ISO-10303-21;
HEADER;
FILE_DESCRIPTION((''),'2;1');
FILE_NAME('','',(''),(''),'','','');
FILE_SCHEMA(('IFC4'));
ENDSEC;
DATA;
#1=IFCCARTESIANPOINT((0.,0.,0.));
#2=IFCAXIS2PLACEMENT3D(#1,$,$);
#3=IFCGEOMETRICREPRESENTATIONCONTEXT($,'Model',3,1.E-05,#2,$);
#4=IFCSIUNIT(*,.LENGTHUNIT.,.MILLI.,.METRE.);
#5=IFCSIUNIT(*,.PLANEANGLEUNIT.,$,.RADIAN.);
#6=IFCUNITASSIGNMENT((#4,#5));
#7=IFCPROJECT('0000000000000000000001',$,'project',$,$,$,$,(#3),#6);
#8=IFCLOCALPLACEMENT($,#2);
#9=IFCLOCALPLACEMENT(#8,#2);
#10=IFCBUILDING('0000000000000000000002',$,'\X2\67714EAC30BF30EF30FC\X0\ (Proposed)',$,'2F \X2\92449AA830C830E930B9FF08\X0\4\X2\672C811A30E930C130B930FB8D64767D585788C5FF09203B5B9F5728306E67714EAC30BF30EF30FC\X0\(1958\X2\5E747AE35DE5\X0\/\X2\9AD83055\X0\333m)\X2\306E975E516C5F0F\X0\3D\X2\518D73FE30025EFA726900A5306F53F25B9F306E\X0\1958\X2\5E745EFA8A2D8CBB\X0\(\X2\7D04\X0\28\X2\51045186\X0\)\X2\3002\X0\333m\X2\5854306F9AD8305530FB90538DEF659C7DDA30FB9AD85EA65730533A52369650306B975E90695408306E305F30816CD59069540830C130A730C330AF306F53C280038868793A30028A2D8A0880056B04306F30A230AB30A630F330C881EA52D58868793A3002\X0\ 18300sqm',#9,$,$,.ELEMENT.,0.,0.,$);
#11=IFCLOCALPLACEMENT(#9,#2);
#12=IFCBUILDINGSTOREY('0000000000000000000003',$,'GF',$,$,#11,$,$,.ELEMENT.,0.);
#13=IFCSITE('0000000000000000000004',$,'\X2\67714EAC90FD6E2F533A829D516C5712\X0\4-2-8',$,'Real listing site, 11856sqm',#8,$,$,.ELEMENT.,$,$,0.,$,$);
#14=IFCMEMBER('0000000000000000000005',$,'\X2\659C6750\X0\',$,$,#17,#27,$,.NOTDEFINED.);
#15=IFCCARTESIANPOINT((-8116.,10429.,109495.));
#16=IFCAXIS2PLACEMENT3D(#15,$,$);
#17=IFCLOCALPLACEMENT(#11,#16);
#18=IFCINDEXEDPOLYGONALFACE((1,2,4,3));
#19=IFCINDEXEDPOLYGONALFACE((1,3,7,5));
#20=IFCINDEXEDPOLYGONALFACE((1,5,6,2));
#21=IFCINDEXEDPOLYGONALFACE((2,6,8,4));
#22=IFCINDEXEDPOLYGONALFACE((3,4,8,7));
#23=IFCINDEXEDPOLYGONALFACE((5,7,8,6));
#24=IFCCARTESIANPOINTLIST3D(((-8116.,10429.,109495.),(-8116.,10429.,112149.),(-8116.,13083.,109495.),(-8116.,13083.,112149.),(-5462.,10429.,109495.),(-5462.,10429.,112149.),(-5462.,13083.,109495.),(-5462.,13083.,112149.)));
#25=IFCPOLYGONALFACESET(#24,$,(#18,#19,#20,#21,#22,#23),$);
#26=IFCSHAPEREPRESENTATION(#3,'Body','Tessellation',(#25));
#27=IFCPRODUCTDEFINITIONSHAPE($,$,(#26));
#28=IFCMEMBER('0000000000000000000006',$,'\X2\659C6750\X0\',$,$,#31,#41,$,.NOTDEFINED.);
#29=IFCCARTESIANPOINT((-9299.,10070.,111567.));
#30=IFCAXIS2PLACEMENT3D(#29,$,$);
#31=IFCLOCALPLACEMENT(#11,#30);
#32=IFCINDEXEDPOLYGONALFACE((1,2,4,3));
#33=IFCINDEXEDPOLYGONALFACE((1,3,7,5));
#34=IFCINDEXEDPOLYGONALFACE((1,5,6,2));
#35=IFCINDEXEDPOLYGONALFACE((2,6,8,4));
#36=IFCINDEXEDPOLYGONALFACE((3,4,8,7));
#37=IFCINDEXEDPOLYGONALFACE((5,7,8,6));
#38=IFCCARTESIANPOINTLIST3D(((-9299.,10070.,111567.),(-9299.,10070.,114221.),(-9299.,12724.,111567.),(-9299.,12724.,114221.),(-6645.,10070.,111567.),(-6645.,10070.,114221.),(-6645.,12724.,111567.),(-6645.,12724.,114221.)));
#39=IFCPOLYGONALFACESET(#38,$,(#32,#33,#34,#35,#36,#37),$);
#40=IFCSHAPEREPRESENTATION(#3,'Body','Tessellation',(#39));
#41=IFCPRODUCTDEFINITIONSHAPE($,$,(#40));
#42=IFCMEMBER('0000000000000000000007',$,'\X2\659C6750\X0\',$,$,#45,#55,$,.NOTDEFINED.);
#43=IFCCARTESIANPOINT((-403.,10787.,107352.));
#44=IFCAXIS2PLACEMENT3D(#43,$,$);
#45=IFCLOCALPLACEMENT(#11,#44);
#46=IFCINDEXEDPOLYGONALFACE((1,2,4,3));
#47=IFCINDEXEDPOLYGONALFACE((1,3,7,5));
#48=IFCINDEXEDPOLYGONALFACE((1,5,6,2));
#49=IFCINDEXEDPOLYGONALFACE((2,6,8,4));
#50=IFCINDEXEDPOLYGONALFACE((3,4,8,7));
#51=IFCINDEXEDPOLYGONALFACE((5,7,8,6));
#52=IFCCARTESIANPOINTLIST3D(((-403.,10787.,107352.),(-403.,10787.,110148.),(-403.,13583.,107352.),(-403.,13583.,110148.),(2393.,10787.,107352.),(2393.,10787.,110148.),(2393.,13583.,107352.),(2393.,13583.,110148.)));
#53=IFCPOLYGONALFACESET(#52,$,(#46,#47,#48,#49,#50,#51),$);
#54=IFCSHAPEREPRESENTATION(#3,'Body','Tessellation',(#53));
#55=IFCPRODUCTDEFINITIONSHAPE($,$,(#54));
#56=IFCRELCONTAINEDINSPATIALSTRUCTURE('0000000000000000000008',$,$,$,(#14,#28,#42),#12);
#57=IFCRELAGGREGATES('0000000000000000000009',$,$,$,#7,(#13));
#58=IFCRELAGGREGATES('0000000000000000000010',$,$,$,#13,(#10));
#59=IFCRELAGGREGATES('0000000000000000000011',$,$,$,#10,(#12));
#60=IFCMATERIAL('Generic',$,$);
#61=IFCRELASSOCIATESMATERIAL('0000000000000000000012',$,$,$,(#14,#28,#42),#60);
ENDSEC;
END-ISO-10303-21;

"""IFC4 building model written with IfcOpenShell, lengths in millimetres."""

from ifc_helpers import new_model, si_unit, frame, frame_2d, origin, place, context, project, spatial, rectangle, extrude, material, element, save


model = new_model("IFC4")

# Units and contexts
model_context = context("Model", 3, precision=1e-05, world=origin())
ifc_project = project(units=[si_unit("LENGTHUNIT", "METRE", prefix="MILLI"), si_unit("PLANEANGLEUNIT", "RADIAN")], contexts=[model_context])

# Site, building, storey
site_placement = place(None, origin())
site = spatial("IfcSite", under=ifc_project, at=site_placement, Name="東京都港区芝公園4-2-8", ObjectType="Real listing site, 11856sqm", CompositionType="ELEMENT", RefElevation=0.0)
building_placement = place(site_placement, origin())
building = spatial("IfcBuilding", under=site, at=building_placement, Name="東京タワー (Proposed)", ObjectType="2F 鉄骨トラス（4本脚ラチス・赤白塗装）※実在の東京タワー(1958年竣工/高さ333m)の非公式3D再現。建物¥は史実の1958年建設費(約28億円)。333m塔は高さ・道路斜線・高度地区制限に非適合のため法適合チェックは参考表示。設計者欄はアカウント自動表示。 18300sqm", CompositionType="ELEMENT", ElevationOfRefHeight=0.0, ElevationOfTerrain=0.0)
storey_placement = place(building_placement, origin())
storey = spatial("IfcBuildingStorey", under=building, at=storey_placement, Name="GF", CompositionType="ELEMENT", Elevation=0.0)

# Shared definitions
ifc_material = material(Name="Generic")

# Members
member_1_placement = place(storey_placement, frame((-8116.0, 10429.0, 109495.0)))
element("IfcMember", 1, at=member_1_placement, inside=storey, material=ifc_material, Name="斜材", PredefinedType="NOTDEFINED", context=model_context, shape_type="SweptSolid", body=[
    extrude(rectangle(XDim=2654.0, YDim=2654.0, at=frame_2d((1327.0, 1327.0))), frame((-8116.0, 10429.0, 109495.0)), (0.0, 0.0, 1.0), 2654.0),
])
member_2_placement = place(storey_placement, frame((-9299.0, 10070.0, 111567.0)))
element("IfcMember", 2, at=member_2_placement, inside=storey, material=ifc_material, Name="斜材", PredefinedType="NOTDEFINED", context=model_context, shape_type="SweptSolid", body=[
    extrude(rectangle(XDim=2654.0, YDim=2654.0, at=frame_2d((1327.0, 1327.0))), frame((-9299.0, 10070.0, 111567.0)), (0.0, 0.0, 1.0), 2654.0),
])
member_3_placement = place(storey_placement, frame((-403.0, 10787.0, 107352.0)))
element("IfcMember", 3, at=member_3_placement, inside=storey, material=ifc_material, Name="斜材", PredefinedType="NOTDEFINED", context=model_context, shape_type="SweptSolid", body=[
    extrude(rectangle(XDim=2796.0, YDim=2796.0, at=frame_2d((1398.0, 1398.0))), frame((-403.0, 10787.0, 107352.0)), (0.0, 0.0, 1.0), 2796.0),
])

save(model, "model.ifc")
